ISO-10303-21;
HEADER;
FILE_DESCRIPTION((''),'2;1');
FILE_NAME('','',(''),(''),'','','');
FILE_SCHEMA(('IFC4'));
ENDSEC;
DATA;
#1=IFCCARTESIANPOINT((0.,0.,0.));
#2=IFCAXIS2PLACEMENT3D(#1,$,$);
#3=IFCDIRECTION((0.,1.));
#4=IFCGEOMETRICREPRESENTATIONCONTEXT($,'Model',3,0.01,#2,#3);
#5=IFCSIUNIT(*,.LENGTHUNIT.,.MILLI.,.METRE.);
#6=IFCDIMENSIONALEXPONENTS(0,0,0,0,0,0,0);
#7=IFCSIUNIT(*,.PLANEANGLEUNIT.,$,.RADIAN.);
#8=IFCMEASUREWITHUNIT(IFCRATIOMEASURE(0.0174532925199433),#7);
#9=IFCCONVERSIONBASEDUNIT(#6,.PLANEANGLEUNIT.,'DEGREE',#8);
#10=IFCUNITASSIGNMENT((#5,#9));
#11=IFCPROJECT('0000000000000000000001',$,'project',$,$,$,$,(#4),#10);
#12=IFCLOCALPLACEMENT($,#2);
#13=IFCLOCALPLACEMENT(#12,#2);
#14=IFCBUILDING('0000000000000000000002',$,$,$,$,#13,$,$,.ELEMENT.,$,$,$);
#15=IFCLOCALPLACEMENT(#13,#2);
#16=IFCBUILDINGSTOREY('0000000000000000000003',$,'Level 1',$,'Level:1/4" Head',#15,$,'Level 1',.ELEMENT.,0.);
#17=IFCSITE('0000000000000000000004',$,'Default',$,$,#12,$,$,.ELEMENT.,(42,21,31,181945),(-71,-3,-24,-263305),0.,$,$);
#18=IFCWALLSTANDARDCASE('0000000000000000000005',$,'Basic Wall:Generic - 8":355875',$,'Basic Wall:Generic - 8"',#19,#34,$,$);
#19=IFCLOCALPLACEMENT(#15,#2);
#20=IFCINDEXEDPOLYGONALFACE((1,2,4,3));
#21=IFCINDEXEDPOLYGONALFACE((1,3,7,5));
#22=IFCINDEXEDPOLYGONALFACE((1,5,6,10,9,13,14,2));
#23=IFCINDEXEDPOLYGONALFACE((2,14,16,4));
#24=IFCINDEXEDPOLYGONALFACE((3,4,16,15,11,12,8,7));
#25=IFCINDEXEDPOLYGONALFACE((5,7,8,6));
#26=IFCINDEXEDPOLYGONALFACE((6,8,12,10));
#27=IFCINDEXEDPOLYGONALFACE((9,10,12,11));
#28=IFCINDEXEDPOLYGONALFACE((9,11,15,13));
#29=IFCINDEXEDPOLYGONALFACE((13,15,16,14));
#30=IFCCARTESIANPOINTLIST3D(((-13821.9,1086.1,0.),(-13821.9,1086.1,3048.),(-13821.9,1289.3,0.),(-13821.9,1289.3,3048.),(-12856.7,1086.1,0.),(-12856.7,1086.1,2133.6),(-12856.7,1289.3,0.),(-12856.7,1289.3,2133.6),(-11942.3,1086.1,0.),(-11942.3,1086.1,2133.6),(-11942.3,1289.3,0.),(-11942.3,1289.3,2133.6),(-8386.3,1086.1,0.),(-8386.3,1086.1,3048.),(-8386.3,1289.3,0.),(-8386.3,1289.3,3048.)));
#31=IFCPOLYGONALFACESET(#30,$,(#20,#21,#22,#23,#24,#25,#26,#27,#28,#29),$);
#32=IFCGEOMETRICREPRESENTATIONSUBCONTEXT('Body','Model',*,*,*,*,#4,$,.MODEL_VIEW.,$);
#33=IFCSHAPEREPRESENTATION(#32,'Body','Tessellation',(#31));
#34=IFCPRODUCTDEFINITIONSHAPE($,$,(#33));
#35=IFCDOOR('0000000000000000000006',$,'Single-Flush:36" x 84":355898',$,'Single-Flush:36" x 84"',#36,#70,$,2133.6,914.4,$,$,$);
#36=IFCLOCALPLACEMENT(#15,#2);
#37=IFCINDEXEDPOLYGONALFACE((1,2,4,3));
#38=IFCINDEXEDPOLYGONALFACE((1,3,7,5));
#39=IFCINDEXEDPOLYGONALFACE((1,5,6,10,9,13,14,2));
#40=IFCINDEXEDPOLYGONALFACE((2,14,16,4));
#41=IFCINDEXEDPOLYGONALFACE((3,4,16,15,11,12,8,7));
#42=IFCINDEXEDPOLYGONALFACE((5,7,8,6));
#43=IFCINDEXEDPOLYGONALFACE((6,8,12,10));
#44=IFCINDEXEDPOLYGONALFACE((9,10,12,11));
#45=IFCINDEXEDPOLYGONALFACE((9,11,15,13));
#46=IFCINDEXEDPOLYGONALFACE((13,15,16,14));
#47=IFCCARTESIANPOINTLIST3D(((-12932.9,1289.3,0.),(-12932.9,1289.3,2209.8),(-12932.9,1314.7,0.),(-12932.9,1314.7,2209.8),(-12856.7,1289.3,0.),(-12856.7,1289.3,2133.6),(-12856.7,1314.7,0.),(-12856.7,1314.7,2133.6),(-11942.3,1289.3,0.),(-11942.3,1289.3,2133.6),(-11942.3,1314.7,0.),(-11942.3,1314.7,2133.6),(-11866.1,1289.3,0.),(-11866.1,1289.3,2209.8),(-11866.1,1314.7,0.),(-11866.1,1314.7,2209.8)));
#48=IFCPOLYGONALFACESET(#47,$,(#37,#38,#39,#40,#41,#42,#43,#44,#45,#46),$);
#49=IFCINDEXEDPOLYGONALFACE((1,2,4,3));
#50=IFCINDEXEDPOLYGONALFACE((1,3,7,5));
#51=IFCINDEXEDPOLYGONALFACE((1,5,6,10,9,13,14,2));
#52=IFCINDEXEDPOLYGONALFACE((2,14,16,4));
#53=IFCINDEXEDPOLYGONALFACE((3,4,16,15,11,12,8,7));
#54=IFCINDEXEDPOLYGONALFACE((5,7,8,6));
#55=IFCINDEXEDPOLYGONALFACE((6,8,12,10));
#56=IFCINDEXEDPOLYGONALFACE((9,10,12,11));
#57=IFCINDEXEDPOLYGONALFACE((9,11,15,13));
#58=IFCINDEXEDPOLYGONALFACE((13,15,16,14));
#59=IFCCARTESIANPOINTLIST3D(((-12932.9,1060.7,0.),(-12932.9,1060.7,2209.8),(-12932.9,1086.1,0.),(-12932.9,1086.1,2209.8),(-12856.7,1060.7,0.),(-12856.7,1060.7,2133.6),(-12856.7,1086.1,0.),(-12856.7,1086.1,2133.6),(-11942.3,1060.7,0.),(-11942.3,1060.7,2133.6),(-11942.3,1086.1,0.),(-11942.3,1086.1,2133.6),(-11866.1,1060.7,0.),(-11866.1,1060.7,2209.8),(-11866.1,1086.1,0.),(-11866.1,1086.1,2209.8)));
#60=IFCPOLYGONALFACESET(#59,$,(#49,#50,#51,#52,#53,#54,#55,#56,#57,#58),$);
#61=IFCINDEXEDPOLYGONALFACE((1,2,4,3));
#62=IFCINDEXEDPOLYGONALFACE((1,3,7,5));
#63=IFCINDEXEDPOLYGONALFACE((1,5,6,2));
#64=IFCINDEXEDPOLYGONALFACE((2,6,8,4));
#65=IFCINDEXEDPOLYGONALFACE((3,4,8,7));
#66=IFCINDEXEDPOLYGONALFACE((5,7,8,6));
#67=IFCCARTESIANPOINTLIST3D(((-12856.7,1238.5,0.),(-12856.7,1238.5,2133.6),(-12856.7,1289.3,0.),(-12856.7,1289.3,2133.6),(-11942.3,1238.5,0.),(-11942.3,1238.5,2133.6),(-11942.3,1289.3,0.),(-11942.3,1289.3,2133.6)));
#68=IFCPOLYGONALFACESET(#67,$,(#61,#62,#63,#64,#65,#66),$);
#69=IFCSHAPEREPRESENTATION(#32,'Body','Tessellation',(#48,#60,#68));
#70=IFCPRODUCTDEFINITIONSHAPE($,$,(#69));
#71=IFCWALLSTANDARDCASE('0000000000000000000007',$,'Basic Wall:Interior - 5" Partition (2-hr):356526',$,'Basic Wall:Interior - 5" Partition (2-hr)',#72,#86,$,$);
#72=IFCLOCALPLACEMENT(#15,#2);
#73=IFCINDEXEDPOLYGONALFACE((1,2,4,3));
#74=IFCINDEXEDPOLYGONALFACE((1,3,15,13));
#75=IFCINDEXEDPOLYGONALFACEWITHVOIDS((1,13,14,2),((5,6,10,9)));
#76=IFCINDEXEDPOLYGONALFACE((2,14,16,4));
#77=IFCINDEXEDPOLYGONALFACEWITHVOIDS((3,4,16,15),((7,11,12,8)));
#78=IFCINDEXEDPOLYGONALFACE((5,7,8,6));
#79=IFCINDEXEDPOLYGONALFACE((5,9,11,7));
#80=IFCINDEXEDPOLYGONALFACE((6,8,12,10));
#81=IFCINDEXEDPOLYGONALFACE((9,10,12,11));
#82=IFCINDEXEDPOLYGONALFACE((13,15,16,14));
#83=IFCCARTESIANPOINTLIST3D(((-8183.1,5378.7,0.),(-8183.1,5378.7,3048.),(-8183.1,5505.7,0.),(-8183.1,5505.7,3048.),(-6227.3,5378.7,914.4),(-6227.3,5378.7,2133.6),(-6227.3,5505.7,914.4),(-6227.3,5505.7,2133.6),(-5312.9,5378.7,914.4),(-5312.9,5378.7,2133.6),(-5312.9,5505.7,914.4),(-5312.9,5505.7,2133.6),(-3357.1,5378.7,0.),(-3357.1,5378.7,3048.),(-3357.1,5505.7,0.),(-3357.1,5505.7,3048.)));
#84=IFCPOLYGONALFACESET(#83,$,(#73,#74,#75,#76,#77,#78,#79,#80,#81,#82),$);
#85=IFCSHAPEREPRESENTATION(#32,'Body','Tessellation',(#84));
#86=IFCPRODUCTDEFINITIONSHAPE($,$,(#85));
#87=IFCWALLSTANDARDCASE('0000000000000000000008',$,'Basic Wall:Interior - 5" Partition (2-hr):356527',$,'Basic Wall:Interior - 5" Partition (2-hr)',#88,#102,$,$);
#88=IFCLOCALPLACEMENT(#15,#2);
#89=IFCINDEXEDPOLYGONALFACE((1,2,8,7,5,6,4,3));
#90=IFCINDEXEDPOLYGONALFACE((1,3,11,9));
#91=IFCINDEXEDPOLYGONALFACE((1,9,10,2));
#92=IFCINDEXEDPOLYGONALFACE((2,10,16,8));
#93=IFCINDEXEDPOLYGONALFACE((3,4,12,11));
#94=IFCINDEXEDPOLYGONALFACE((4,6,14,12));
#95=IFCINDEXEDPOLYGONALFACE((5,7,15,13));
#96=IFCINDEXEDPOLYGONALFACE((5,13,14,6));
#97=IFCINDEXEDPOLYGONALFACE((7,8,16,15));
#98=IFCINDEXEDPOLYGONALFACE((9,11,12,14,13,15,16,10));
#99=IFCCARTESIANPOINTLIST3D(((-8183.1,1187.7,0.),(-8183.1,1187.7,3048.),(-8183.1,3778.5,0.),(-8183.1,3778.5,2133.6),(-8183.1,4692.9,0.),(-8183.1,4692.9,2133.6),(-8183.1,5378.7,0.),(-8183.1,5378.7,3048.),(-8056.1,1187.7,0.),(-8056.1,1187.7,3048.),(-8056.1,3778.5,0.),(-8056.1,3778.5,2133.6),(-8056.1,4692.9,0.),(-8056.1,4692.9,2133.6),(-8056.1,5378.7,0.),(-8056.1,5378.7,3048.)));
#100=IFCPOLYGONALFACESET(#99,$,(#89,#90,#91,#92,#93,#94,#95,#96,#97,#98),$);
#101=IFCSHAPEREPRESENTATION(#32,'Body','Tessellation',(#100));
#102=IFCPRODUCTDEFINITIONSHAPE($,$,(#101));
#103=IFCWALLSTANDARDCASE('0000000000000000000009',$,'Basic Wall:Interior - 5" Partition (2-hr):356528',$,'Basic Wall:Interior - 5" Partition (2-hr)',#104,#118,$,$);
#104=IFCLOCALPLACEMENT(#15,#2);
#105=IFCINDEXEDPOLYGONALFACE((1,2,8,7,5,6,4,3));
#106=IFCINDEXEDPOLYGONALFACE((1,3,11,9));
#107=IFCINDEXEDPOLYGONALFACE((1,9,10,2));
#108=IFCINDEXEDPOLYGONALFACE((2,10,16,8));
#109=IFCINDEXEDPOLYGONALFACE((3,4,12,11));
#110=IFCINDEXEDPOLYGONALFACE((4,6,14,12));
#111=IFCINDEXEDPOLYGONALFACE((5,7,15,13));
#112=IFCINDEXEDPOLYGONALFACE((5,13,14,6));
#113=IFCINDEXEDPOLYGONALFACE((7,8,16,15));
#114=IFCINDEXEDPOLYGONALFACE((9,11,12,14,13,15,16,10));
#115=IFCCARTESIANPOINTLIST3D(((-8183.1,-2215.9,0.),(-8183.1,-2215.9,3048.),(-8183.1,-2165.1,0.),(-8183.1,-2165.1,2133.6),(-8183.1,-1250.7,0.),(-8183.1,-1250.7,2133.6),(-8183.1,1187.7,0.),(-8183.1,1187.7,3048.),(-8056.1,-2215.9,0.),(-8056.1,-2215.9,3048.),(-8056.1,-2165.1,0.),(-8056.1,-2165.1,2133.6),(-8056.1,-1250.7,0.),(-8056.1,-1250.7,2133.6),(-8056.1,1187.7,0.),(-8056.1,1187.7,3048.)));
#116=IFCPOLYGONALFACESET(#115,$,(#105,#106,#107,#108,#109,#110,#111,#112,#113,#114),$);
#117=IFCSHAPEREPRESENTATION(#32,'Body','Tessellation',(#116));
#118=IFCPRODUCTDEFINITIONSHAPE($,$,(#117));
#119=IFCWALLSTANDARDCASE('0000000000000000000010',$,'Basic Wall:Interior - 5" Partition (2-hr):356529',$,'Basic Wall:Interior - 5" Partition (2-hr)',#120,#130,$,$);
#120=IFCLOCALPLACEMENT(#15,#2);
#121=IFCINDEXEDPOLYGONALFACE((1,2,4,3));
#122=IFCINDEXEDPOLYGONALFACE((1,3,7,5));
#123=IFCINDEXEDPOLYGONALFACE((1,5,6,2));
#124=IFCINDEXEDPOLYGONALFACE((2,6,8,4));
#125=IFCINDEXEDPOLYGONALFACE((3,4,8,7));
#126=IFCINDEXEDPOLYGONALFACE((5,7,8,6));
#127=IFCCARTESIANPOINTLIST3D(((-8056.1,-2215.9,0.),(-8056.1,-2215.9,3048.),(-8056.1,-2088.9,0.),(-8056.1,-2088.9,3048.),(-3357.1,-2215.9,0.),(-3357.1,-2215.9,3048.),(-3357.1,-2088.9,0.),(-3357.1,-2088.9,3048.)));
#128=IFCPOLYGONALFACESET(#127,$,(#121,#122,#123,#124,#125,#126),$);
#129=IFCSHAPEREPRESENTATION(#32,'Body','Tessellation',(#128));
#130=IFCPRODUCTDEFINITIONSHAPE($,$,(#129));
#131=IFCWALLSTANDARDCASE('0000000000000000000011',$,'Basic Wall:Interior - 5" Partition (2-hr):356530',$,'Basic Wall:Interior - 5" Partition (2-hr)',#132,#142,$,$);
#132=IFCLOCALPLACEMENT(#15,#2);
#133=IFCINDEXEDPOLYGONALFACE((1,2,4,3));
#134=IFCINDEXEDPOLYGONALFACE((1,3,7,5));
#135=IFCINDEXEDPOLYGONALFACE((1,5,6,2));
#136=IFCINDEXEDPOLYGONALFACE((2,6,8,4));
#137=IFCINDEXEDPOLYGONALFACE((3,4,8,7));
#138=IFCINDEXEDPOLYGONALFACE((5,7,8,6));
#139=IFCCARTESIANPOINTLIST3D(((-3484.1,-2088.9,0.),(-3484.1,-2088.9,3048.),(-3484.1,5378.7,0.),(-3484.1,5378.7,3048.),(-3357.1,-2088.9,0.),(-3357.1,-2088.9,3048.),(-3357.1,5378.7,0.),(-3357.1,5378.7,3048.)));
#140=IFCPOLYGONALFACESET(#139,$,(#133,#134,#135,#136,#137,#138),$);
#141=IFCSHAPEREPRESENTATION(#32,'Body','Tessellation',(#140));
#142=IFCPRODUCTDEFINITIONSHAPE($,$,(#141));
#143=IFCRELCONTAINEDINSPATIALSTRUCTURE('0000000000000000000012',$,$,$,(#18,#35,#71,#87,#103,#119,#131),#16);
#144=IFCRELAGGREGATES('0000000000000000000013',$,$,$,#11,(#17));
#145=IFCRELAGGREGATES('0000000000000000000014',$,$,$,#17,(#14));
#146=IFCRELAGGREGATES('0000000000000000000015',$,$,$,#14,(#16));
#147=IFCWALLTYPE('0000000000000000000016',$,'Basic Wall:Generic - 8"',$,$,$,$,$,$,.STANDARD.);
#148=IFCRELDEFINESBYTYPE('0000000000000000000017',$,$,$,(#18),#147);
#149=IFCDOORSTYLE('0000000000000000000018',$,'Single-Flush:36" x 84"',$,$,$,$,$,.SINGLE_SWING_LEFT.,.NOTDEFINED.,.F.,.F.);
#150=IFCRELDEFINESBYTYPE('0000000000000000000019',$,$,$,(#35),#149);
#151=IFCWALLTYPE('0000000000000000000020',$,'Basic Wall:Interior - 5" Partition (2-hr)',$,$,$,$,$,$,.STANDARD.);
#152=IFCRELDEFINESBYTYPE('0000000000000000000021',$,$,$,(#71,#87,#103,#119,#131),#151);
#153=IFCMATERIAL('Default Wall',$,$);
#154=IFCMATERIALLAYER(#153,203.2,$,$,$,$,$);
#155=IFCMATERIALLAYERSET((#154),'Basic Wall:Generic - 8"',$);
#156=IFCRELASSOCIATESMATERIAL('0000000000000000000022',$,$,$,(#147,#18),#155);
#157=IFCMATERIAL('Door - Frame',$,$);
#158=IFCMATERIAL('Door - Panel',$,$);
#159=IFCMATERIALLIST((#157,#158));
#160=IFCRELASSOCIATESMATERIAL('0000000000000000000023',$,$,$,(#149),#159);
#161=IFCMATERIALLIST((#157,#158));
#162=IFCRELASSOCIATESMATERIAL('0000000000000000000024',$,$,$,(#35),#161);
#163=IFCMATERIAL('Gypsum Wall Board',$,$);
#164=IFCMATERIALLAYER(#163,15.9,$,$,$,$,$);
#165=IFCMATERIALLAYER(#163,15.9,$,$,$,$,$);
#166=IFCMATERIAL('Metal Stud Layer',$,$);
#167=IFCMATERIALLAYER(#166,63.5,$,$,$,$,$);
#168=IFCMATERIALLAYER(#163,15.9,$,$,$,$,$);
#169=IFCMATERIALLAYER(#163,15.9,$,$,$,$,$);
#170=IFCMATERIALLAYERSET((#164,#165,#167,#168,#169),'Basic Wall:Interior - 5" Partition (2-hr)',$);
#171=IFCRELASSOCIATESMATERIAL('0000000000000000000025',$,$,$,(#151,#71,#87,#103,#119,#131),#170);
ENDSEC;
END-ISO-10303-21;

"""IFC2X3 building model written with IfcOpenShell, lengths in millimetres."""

from ifc_helpers import new_model, entity, si_unit, converted_unit, direction, frame, frame_2d, origin, origin_2d_with_axis, place, context, subcontext, project, spatial, polyline, rectangle, outline, extrude, source, transform, mapped, material, material_list, layer, layer_set, layer_usage, type_object, type_shapes, element, fill, save


model = new_model("IFC2X3")

# Units and contexts
model_context = context("Model", 3, precision=0.01, world=origin(), true_north=direction((0.0, 1.0)))
body_context = subcontext(model_context, "Body", "Model", "MODEL_VIEW")
ifc_project = project(units=[si_unit("LENGTHUNIT", "METRE", prefix="MILLI"), converted_unit("PLANEANGLEUNIT", "DEGREE", entity("IfcRatioMeasure", 0.0174532925199433), si_unit("PLANEANGLEUNIT", "RADIAN"), dimensions=[0, 0, 0, 0, 0, 0, 0])], contexts=[model_context])

# Site, building, storey
site_placement = place(None, origin())
site = spatial("IfcSite", under=ifc_project, at=site_placement, Name="Default", CompositionType="ELEMENT", RefLatitude=(42, 21, 31, 181945), RefLongitude=(-71, -3, -24, -263305), RefElevation=0.0)
building_placement = place(site_placement, origin())
building = spatial("IfcBuilding", under=site, at=building_placement, CompositionType="ELEMENT")
storey_placement = place(building_placement, origin())
storey = spatial("IfcBuildingStorey", under=building, at=storey_placement, Name="Level 1", ObjectType="Level:1/4\" Head", LongName="Level 1", CompositionType="ELEMENT", Elevation=0.0)

# Shared definitions
ifc_material_1 = material(Name="Default Wall")
ifc_layer_1 = layer(ifc_material_1, 203.2)
ifc_layer_set_1 = layer_set([ifc_layer_1], Name="Basic Wall:Generic - 8\"")
wall_type_1 = type_object("IfcWallType", Name="Basic Wall:Generic - 8\"", PredefinedType="STANDARD", material=ifc_layer_set_1)

# Shared definitions
ifc_material_2 = material(Name="Door - Frame")
ifc_material_3 = material(Name="Door - Panel")
ifc_material_list_1 = material_list([ifc_material_2, ifc_material_3])
door_style_1 = type_object("IfcDoorStyle", Name="Single-Flush:36\" x 84\"", ConstructionType="NOTDEFINED", OperationType="SINGLE_SWING_LEFT", ParameterTakesPrecedence=False, Sizeable=False, material=ifc_material_list_1)
shared_shape_1 = source(origin(), body_context, "Body", "SweptSolid", [
    extrude(outline(polyline([(-533.4, -1124.0), (533.4, -1124.0), (533.4, 1085.8), (457.2, 1085.8), (457.2, -1047.8), (-457.2, -1047.8), (-457.2, 1085.8), (-533.4, 1085.8), (-533.4, -1124.0)])), frame((457.2, 228.6, 1085.8), z_axis=(0.0, -1.0, 0.0), x_axis=(-1.0, 0.0, 0.0)), (0.0, 0.0, 1.0), 25.4),
    extrude(outline(polyline([(-1124.0, -533.4), (1085.8, -533.4), (1085.8, -457.2), (-1047.8, -457.2), (-1047.8, 457.2), (1085.8, 457.2), (1085.8, 533.4), (-1124.0, 533.4), (-1124.0, -533.4)])), frame((457.2, 0.0, 1085.8), z_axis=(0.0, -1.0, 0.0), x_axis=(0.0, 0.0, -1.0)), (0.0, 0.0, 1.0), 25.4),
    extrude(rectangle(XDim=914.4, YDim=50.8, at=frame_2d((0.0, 0.0), x_axis=(1.0, 0.0))), frame((457.2, 177.8, 0.0)), (0.0, 0.0, 1.0), 2133.6),
])
type_shapes(door_style_1, [shared_shape_1])

# Wall, opening, door
ifc_layer_usage_1 = layer_usage(ifc_layer_set_1, "AXIS2", "NEGATIVE", 101.6)
wall_1_placement = place(storey_placement, frame((-13821.9, 1187.7, 0.0)))
wall_1 = element("IfcWallStandardCase", 1, at=wall_1_placement, inside=storey, type_object=wall_type_1, material=ifc_layer_usage_1, Name="Basic Wall:Generic - 8\":355875", ObjectType="Basic Wall:Generic - 8\"", context=body_context, shape_type="SweptSolid", body=[
    extrude(rectangle(XDim=5435.6, YDim=203.2, at=frame_2d((2717.8, 0.0), x_axis=(-1.0, 0.0))), origin(), (0.0, 0.0, 1.0), 3048.0),
])
opening_1_placement = place(wall_1_placement, frame((965.2, -101.6, 0.0)))
opening_1 = element("IfcOpeningElement", 2, at=opening_1_placement, cuts=wall_1, ObjectType="Opening", context=body_context, shape_type="SweptSolid", body=[
    extrude(rectangle(XDim=914.4, YDim=2133.6, at=frame_2d((1066.8, 457.2), x_axis=(0.0, -1.0))), frame((0.0, 0.0, 0.0), z_axis=(0.0, 1.0, 0.0), x_axis=(0.0, 0.0, 1.0)), (0.0, 0.0, 1.0), 203.2),
])
ifc_material_list_2 = material_list([ifc_material_2, ifc_material_3])
door_1_placement = place(opening_1_placement, origin())
door_1 = element("IfcDoor", 3, at=door_1_placement, inside=storey, type_object=door_style_1, material=ifc_material_list_2, Name="Single-Flush:36\" x 84\":355898", ObjectType="Single-Flush:36\" x 84\"", OverallHeight=2133.6, OverallWidth=914.4, context=body_context, shape_type="MappedRepresentation", body=[
    mapped(shared_shape_1, transform((0.0, 0.0, 0.0), scale=1.0)),
])
fill(opening_1, door_1)

# Walls, openings
ifc_material_4 = material(Name="Gypsum Wall Board")
ifc_layer_2 = layer(ifc_material_4, 15.9)
ifc_layer_3 = layer(ifc_material_4, 15.9)
ifc_material_5 = material(Name="Metal Stud Layer")
ifc_layer_4 = layer(ifc_material_5, 63.5)
ifc_layer_5 = layer(ifc_material_4, 15.9)
ifc_layer_6 = layer(ifc_material_4, 15.9)
ifc_layer_set_2 = layer_set([ifc_layer_2, ifc_layer_3, ifc_layer_4, ifc_layer_5, ifc_layer_6], Name="Basic Wall:Interior - 5\" Partition (2-hr)")
ifc_layer_usage_2 = layer_usage(ifc_layer_set_2, "AXIS2", "NEGATIVE", 63.5)
wall_type_2 = type_object("IfcWallType", Name="Basic Wall:Interior - 5\" Partition (2-hr)", PredefinedType="STANDARD", material=ifc_layer_set_2)
wall_2_placement = place(storey_placement, frame((-3357.1, 5442.2, 0.0), z_axis=(0.0, 0.0, 1.0), x_axis=(-1.0, 0.0, 0.0)))
wall_2 = element("IfcWallStandardCase", 4, at=wall_2_placement, inside=storey, type_object=wall_type_2, material=ifc_layer_usage_2, Name="Basic Wall:Interior - 5\" Partition (2-hr):356526", ObjectType="Basic Wall:Interior - 5\" Partition (2-hr)", context=body_context, shape_type="SweptSolid", body=[
    extrude(rectangle(XDim=4826.0, YDim=127.0, at=frame_2d((2413.0, 0.0), x_axis=(-1.0, 0.0))), origin(), (0.0, 0.0, 1.0), 3048.0),
])
opening_2_placement = place(wall_2_placement, origin())
element("IfcOpeningElement", 5, at=opening_2_placement, cuts=wall_2, ObjectType="Opening", context=body_context, shape_type="SweptSolid", body=[
    extrude(rectangle(XDim=1219.2, YDim=914.4, at=origin_2d_with_axis()), frame((2413.0, -1790.7, 1524.0), z_axis=(0.0, 1.0, 0.0), x_axis=(0.0, 0.0, -1.0)), (0.0, 0.0, 1.0), 3048.0),
])
ifc_layer_usage_3 = layer_usage(ifc_layer_set_2, "AXIS2", "NEGATIVE", 63.5)
wall_3_placement = place(storey_placement, frame((-8119.6, 5378.7, 0.0), z_axis=(0.0, 0.0, 1.0), x_axis=(0.0, -1.0, 0.0)))
wall_3 = element("IfcWallStandardCase", 6, at=wall_3_placement, inside=storey, type_object=wall_type_2, material=ifc_layer_usage_3, Name="Basic Wall:Interior - 5\" Partition (2-hr):356527", ObjectType="Basic Wall:Interior - 5\" Partition (2-hr)", context=body_context, shape_type="SweptSolid", body=[
    extrude(rectangle(XDim=4191.0, YDim=127.0, at=frame_2d((2095.5, 0.0), x_axis=(-1.0, 0.0))), origin(), (0.0, 0.0, 1.0), 3048.0),
])
opening_3_placement = place(wall_3_placement, origin())
element("IfcOpeningElement", 7, at=opening_3_placement, cuts=wall_3, ObjectType="Opening", context=body_context, shape_type="SweptSolid", body=[
    extrude(rectangle(XDim=2133.6, YDim=914.4, at=frame_2d((0.0, 0.0), x_axis=(0.0, 1.0))), frame((1143.0, -1587.5, 1066.8), z_axis=(0.0, 1.0, 0.0), x_axis=(-1.0, 0.0, 0.0)), (0.0, 0.0, 1.0), 3048.0),
])
ifc_layer_usage_4 = layer_usage(ifc_layer_set_2, "AXIS2", "NEGATIVE", 63.5)
wall_4_placement = place(storey_placement, frame((-8119.6, 1187.7, 0.0), z_axis=(0.0, 0.0, 1.0), x_axis=(0.0, -1.0, 0.0)))
wall_4 = element("IfcWallStandardCase", 8, at=wall_4_placement, inside=storey, type_object=wall_type_2, material=ifc_layer_usage_4, Name="Basic Wall:Interior - 5\" Partition (2-hr):356528", ObjectType="Basic Wall:Interior - 5\" Partition (2-hr)", context=body_context, shape_type="SweptSolid", body=[
    extrude(rectangle(XDim=3403.6, YDim=127.0, at=frame_2d((1701.8, 0.0), x_axis=(-1.0, 0.0))), origin(), (0.0, 0.0, 1.0), 3048.0),
])
opening_4_placement = place(wall_4_placement, origin())
element("IfcOpeningElement", 9, at=opening_4_placement, cuts=wall_4, ObjectType="Opening", context=body_context, shape_type="SweptSolid", body=[
    extrude(rectangle(XDim=2133.6, YDim=914.4, at=origin_2d_with_axis()), frame((2895.6, -1790.7, 1066.8), z_axis=(0.0, 1.0, 0.0), x_axis=(0.0, 0.0, 1.0)), (0.0, 0.0, 1.0), 3048.0),
])

# Walls
ifc_layer_usage_5 = layer_usage(ifc_layer_set_2, "AXIS2", "NEGATIVE", 63.5)
wall_5_placement = place(storey_placement, frame((-8056.1, -2152.4, 0.0)))
element("IfcWallStandardCase", 10, at=wall_5_placement, inside=storey, type_object=wall_type_2, material=ifc_layer_usage_5, Name="Basic Wall:Interior - 5\" Partition (2-hr):356529", ObjectType="Basic Wall:Interior - 5\" Partition (2-hr)", context=body_context, shape_type="SweptSolid", body=[
    extrude(rectangle(XDim=4699.0, YDim=127.0, at=frame_2d((2349.5, 0.0), x_axis=(-1.0, 0.0))), origin(), (0.0, 0.0, 1.0), 3048.0),
])
ifc_layer_usage_6 = layer_usage(ifc_layer_set_2, "AXIS2", "NEGATIVE", 63.5)
wall_6_placement = place(storey_placement, frame((-3420.6, -2088.9, 0.0), z_axis=(0.0, 0.0, 1.0), x_axis=(0.0, 1.0, 0.0)))
element("IfcWallStandardCase", 11, at=wall_6_placement, inside=storey, type_object=wall_type_2, material=ifc_layer_usage_6, Name="Basic Wall:Interior - 5\" Partition (2-hr):356530", ObjectType="Basic Wall:Interior - 5\" Partition (2-hr)", context=body_context, shape_type="SweptSolid", body=[
    extrude(rectangle(XDim=7467.6, YDim=127.0, at=frame_2d((3733.8, 0.0), x_axis=(-1.0, 0.0))), origin(), (0.0, 0.0, 1.0), 3048.0),
])

save(model, "model.ifc")
